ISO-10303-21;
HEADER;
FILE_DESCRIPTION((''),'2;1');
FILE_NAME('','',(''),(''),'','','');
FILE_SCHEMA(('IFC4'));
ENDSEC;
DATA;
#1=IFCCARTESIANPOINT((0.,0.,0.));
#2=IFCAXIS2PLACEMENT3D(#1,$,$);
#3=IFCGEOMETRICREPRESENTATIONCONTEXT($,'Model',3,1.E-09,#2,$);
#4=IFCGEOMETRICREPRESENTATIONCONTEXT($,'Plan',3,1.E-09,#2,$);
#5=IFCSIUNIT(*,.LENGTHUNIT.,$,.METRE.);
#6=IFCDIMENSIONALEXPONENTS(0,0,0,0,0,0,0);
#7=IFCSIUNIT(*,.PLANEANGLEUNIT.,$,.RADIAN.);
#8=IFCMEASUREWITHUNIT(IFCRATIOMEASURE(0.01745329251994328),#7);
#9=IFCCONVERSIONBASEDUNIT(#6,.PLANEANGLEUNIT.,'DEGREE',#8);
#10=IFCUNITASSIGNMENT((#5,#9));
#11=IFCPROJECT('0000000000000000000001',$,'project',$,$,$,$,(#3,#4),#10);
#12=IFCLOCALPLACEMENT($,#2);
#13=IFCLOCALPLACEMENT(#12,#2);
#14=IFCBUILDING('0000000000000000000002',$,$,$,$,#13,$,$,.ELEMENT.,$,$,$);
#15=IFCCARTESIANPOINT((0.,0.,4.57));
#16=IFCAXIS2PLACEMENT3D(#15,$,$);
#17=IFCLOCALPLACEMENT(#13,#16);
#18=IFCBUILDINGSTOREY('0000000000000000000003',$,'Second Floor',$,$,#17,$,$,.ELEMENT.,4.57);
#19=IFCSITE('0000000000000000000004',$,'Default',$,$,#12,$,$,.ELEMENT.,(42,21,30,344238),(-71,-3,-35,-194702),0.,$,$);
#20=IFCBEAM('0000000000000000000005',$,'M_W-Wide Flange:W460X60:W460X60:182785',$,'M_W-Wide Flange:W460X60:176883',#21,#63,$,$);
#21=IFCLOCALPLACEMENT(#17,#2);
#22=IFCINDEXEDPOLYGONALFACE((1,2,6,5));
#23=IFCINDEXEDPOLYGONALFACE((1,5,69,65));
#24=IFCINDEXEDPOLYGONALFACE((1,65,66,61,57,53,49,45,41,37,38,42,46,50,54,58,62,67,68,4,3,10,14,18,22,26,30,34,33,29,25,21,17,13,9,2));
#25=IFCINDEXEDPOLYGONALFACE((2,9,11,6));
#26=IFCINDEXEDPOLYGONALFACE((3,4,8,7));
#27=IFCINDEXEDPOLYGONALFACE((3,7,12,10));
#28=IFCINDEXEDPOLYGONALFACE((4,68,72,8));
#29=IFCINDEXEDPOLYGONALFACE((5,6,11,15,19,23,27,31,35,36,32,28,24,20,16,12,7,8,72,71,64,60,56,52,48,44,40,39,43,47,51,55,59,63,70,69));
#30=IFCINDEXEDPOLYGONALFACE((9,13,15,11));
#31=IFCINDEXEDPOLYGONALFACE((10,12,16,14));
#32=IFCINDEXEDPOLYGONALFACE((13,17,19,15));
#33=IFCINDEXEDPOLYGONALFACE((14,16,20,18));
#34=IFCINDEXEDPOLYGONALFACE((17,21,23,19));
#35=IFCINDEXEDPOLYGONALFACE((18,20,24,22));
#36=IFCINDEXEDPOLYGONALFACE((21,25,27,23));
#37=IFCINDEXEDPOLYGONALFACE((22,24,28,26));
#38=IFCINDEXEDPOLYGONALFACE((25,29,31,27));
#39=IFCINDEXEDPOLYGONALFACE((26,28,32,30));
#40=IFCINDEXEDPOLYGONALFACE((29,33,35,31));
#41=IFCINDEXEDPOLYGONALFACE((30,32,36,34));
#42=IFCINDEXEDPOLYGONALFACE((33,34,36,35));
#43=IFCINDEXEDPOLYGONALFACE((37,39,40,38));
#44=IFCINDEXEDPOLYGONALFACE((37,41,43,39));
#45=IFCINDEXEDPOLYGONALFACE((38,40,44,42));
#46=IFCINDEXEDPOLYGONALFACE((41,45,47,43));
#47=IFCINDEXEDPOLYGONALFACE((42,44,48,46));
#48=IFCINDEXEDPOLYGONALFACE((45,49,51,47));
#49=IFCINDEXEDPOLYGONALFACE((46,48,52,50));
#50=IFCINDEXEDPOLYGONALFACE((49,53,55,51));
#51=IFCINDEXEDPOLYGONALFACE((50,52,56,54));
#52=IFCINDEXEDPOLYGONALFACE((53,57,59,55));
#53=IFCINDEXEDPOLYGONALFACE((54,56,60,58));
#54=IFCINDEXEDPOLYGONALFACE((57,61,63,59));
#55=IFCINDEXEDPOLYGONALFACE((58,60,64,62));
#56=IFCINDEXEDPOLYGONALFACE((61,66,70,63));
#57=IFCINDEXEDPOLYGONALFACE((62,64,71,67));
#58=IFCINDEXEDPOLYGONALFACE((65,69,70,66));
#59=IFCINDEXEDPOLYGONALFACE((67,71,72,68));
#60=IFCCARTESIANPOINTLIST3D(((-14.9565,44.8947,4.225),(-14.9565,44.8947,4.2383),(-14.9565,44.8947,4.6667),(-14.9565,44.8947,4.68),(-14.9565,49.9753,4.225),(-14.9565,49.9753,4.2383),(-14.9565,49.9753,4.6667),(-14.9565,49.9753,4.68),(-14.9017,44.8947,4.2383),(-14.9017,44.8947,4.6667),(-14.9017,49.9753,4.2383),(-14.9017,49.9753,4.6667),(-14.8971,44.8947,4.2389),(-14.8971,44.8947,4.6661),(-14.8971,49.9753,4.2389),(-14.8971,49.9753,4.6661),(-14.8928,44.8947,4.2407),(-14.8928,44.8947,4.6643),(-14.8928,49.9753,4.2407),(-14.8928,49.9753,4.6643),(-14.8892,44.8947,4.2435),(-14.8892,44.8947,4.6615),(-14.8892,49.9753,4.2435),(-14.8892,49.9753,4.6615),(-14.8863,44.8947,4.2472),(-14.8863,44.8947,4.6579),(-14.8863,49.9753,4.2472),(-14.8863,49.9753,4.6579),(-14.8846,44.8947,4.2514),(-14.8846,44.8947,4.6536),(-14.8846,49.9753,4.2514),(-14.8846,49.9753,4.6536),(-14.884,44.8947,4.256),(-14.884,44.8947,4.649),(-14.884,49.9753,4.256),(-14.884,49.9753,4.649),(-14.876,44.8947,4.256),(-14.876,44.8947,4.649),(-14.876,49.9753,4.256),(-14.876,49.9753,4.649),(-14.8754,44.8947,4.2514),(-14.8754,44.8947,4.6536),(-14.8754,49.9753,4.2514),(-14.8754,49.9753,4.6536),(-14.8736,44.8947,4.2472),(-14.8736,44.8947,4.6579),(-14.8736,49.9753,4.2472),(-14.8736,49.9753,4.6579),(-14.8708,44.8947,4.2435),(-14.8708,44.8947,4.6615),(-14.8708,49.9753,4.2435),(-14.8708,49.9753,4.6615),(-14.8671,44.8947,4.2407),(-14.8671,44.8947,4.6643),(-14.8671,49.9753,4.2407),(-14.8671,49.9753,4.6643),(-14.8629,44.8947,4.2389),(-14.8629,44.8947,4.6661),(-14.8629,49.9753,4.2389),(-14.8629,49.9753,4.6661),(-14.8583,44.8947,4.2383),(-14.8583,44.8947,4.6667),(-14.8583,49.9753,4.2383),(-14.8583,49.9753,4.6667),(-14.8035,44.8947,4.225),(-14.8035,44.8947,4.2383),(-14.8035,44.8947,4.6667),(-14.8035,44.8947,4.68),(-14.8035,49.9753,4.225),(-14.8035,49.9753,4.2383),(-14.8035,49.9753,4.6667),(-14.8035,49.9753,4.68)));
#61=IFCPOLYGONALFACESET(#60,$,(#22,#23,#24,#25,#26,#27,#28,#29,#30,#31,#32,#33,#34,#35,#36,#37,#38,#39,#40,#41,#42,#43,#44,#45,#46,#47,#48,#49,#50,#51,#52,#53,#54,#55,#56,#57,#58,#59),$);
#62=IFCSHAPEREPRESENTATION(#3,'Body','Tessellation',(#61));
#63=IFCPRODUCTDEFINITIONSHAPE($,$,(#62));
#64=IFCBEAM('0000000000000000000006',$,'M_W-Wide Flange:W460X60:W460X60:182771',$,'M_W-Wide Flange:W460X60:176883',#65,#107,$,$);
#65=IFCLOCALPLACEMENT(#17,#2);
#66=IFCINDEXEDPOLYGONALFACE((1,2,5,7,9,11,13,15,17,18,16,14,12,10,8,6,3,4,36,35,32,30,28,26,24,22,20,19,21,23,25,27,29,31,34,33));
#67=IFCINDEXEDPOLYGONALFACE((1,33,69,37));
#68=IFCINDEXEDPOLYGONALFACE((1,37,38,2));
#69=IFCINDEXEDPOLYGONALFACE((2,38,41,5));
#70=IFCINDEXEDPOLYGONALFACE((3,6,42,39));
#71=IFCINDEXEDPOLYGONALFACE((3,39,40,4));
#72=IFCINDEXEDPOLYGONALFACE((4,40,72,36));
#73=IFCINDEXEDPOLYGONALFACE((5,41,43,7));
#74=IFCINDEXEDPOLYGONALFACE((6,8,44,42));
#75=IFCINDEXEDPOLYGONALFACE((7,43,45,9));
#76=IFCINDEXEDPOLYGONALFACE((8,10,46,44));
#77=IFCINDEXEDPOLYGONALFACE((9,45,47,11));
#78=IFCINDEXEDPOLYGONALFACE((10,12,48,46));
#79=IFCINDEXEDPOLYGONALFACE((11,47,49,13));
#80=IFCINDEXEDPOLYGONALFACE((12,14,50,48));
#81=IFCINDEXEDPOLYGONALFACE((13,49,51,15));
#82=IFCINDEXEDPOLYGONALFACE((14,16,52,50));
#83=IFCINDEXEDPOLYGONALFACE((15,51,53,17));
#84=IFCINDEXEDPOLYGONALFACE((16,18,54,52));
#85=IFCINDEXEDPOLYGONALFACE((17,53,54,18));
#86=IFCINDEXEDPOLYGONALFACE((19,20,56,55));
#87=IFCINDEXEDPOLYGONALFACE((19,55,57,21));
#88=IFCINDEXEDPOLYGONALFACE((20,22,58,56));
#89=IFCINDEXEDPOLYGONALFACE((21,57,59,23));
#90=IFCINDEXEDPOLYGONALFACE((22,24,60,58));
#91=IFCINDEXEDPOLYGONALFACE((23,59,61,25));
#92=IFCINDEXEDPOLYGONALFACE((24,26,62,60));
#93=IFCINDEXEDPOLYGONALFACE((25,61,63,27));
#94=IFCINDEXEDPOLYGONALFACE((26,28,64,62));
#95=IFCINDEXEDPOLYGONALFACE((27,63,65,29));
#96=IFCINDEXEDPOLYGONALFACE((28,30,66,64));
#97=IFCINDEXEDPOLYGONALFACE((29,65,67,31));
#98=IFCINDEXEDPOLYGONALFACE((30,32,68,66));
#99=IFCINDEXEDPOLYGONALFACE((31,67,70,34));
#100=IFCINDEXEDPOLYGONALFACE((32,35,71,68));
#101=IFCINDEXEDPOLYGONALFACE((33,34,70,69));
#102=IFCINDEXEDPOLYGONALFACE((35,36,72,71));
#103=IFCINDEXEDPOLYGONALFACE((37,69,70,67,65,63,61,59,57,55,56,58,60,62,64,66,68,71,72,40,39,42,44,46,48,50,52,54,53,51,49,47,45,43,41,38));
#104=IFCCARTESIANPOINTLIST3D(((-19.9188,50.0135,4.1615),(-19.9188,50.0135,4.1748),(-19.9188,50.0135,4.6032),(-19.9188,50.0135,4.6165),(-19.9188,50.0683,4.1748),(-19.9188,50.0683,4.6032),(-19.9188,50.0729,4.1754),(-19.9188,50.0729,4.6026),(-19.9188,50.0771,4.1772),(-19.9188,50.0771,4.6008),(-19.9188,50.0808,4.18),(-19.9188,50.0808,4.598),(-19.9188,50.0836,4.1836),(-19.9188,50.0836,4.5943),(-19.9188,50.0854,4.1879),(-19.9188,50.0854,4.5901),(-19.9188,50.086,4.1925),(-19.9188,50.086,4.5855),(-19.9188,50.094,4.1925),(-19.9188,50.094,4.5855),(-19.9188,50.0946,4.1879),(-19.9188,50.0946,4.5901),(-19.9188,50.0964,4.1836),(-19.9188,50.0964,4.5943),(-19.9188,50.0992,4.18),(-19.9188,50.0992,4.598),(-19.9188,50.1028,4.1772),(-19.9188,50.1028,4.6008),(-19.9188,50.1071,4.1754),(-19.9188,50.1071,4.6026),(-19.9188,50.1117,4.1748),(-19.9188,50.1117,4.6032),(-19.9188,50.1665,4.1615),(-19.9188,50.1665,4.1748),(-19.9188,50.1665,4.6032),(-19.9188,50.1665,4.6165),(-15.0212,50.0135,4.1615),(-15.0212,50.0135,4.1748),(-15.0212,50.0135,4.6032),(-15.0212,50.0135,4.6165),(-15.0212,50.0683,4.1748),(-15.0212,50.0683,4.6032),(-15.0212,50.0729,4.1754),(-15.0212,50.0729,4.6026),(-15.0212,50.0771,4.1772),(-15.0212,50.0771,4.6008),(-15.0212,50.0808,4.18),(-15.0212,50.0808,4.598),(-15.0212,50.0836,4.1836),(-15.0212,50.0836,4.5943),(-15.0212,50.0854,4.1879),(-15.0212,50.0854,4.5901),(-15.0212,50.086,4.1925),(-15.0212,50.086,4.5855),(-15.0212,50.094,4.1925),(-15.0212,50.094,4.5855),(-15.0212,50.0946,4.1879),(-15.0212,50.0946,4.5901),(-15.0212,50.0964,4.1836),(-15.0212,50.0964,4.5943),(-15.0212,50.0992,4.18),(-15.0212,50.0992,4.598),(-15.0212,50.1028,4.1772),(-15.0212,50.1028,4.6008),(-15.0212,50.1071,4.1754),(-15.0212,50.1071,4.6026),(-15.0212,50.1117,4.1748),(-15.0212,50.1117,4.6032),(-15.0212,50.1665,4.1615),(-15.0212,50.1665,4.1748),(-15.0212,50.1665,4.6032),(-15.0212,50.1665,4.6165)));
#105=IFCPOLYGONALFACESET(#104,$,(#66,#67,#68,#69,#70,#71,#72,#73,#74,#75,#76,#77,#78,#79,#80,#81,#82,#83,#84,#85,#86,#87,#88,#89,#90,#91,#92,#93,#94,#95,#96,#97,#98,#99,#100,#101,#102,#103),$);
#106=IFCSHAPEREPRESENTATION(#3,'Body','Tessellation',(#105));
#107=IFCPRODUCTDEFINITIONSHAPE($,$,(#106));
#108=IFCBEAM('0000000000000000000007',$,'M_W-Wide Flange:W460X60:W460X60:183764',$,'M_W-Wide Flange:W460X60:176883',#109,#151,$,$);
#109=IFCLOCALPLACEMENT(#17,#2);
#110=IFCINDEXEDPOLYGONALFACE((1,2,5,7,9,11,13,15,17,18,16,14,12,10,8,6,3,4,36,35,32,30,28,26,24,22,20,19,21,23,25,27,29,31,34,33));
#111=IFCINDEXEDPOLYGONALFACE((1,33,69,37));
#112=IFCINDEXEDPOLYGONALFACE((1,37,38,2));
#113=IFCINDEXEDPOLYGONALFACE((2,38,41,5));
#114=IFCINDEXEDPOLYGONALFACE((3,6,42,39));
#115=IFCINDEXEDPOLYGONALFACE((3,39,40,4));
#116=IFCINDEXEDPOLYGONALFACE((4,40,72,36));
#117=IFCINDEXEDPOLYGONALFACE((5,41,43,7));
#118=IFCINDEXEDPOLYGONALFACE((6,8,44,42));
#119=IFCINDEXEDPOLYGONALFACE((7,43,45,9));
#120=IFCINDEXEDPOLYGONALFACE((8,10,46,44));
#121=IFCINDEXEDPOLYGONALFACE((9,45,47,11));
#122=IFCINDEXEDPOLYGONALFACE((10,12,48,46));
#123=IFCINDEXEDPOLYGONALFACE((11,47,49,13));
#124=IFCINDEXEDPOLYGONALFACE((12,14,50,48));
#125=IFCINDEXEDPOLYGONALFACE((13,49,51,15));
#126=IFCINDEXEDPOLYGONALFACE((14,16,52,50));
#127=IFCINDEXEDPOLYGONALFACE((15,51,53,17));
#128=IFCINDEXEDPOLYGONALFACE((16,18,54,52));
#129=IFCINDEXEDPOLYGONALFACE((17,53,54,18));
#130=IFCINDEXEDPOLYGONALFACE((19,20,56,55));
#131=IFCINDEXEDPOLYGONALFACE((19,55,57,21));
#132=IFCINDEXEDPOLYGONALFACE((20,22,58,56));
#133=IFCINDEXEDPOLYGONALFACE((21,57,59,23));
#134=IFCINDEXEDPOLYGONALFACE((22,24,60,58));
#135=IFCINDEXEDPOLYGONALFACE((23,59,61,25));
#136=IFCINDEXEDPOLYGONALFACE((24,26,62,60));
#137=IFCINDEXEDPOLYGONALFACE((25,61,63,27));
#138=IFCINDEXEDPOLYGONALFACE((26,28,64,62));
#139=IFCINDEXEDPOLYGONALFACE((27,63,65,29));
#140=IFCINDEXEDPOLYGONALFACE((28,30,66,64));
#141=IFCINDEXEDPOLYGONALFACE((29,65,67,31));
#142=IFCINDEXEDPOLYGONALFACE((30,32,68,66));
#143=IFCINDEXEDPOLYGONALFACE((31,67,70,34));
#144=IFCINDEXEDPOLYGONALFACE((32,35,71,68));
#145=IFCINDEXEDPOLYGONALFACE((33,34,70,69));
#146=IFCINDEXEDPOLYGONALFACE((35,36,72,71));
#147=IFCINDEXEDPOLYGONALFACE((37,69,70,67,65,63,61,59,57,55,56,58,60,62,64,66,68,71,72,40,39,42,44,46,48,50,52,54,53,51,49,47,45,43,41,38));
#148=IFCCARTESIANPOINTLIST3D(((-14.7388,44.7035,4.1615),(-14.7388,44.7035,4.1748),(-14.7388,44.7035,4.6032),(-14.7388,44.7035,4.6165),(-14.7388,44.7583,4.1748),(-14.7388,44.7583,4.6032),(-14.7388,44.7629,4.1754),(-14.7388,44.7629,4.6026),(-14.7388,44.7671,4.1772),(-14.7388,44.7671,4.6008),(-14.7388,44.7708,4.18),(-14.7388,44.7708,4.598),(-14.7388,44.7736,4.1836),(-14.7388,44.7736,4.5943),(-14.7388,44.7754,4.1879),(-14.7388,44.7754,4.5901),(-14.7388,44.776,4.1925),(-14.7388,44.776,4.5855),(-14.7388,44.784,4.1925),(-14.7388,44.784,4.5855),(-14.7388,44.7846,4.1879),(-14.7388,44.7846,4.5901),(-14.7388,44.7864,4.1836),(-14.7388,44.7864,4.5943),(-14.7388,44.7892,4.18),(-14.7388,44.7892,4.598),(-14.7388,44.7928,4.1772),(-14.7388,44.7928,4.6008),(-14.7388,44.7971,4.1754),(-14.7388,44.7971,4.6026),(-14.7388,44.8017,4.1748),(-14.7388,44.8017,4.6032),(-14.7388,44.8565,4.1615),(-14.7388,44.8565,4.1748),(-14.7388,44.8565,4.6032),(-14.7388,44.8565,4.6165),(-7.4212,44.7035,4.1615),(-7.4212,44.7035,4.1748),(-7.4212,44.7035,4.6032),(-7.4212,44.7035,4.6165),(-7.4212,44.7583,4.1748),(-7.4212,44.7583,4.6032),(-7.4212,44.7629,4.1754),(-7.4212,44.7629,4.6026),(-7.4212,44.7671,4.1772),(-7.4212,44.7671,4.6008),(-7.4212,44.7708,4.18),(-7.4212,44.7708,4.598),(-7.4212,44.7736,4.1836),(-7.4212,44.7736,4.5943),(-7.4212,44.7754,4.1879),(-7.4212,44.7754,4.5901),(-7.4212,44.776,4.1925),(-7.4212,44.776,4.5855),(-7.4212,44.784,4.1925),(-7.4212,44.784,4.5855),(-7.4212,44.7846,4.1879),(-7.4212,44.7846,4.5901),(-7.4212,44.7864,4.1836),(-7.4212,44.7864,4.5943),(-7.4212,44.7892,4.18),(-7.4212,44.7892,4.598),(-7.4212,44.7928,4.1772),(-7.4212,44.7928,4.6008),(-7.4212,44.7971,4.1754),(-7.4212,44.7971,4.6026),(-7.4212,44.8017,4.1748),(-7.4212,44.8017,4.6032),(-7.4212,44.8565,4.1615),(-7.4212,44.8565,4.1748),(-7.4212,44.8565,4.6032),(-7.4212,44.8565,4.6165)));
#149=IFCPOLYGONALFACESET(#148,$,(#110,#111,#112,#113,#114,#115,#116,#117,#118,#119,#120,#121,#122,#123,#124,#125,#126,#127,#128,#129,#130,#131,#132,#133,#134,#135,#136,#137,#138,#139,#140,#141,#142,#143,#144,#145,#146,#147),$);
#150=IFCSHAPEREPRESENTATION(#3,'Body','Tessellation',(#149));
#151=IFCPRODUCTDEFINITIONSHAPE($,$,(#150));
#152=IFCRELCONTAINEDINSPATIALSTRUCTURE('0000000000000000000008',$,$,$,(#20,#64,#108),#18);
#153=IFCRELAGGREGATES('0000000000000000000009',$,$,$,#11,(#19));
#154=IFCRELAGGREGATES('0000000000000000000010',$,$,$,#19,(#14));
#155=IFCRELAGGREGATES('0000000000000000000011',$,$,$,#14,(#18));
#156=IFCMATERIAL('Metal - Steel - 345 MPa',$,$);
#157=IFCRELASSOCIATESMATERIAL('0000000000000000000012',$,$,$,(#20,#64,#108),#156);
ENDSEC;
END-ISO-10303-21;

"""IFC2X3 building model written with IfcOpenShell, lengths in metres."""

from ifc_helpers import new_model, entity, si_unit, converted_unit, frame, frame_2d, origin, place, context, project, spatial, polyline, circle_curve, parameter, trimmed, segment, composite_curve, outline, extrude, material, element, save


model = new_model("IFC2X3")

# Units and contexts
model_context = context("Model", 3, precision=1e-09, world=origin())
plan_context = context("Plan", 3, precision=1e-09, world=origin())
ifc_project = project(units=[si_unit("LENGTHUNIT", "METRE"), converted_unit("PLANEANGLEUNIT", "DEGREE", entity("IfcRatioMeasure", 0.01745329251994328), si_unit("PLANEANGLEUNIT", "RADIAN"), dimensions=[0, 0, 0, 0, 0, 0, 0])], contexts=[model_context, plan_context])

# Site, building, storey
site_placement = place(None, origin())
site = spatial("IfcSite", under=ifc_project, at=site_placement, Name="Default", CompositionType="ELEMENT", RefLatitude=(42, 21, 30, 344238), RefLongitude=(-71, -3, -35, -194702), RefElevation=0.0)
building_placement = place(site_placement, origin())
building = spatial("IfcBuilding", under=site, at=building_placement, CompositionType="ELEMENT")
storey_placement = place(building_placement, frame((0.0, 0.0, 4.57)))
storey = spatial("IfcBuildingStorey", under=building, at=storey_placement, Name="Second Floor", CompositionType="ELEMENT", Elevation=4.57)

# Shared definitions
ifc_material = material(Name="Metal - Steel - 345 MPa")

# Beams
beam_1_placement = place(storey_placement, frame((-14.88, 50.0864, 4.68), z_axis=(0.0, 0.0, 1.0), x_axis=(-1.0, 0.0, 0.0)))
element("IfcBeam", 1, at=beam_1_placement, inside=storey, material=ifc_material, Name="M_W-Wide Flange:W460X60:W460X60:182785", ObjectType="M_W-Wide Flange:W460X60:176883", context=model_context, shape_type="SweptSolid", body=[
    extrude(outline(composite_curve([segment(polyline([(0.2142, -0.0765), (0.2275, -0.0765)]), True, "CONTINUOUS"), segment(polyline([(0.2275, -0.0765), (0.2275, 0.0765)]), True, "CONTINUOUS"), segment(polyline([(0.2275, 0.0765), (0.2142, 0.0765)]), True, "CONTINUOUS"), segment(polyline([(0.2142, 0.0765), (0.2142, 0.0217)]), True, "CONTINUOUS"), segment(trimmed(circle_curve(frame_2d((0.1965, 0.0217), x_axis=(1.0, 0.0)), 0.0177), [parameter(270.0)], [parameter(360.0)], True, "PARAMETER"), False, "CONTINUOUS"), segment(polyline([(0.1965, 0.004), (-0.1965, 0.004)]), True, "CONTINUOUS"), segment(trimmed(circle_curve(frame_2d((-0.1965, 0.0217), x_axis=(0.0, -1.0)), 0.0177), [parameter(270.0)], [parameter(360.0)], True, "PARAMETER"), False, "CONTINUOUS"), segment(polyline([(-0.2142, 0.0217), (-0.2142, 0.0765)]), True, "CONTINUOUS"), segment(polyline([(-0.2142, 0.0765), (-0.2275, 0.0765)]), True, "CONTINUOUS"), segment(polyline([(-0.2275, 0.0765), (-0.2275, -0.0765)]), True, "CONTINUOUS"), segment(polyline([(-0.2275, -0.0765), (-0.2142, -0.0765)]), True, "CONTINUOUS"), segment(polyline([(-0.2142, -0.0765), (-0.2142, -0.0217)]), True, "CONTINUOUS"), segment(trimmed(circle_curve(frame_2d((-0.1965, -0.0217), x_axis=(-1.0, 0.0)), 0.0177), [parameter(270.0)], [parameter(360.0)], True, "PARAMETER"), False, "CONTINUOUS"), segment(polyline([(-0.1965, -0.004), (0.1965, -0.004)]), True, "CONTINUOUS"), segment(trimmed(circle_curve(frame_2d((0.1965, -0.0217), x_axis=(0.0, 1.0)), 0.0177), [parameter(270.0)], [parameter(0.0)], True, "PARAMETER"), False, "CONTINUOUS"), segment(polyline([(0.2142, -0.0217), (0.2142, -0.0765)]), True, "CONTINUOUS")], self_intersect=False)), frame((0.0, 5.1917, -0.2275), z_axis=(0.0, -1.0, 0.0), x_axis=(0.0, 0.0, -1.0)), (0.0, 0.0, 1.0), 5.0806),
])
beam_2_placement = place(storey_placement, frame((-20.0564, 50.09, 4.6165), z_axis=(0.0, 0.0, 1.0), x_axis=(0.0, -1.0, 0.0)))
element("IfcBeam", 2, at=beam_2_placement, inside=storey, material=ifc_material, Name="M_W-Wide Flange:W460X60:W460X60:182771", ObjectType="M_W-Wide Flange:W460X60:176883", context=model_context, shape_type="SweptSolid", body=[
    extrude(outline(composite_curve([segment(polyline([(-0.0765, -0.2142), (-0.0765, -0.2275)]), True, "CONTINUOUS"), segment(polyline([(-0.0765, -0.2275), (0.0765, -0.2275)]), True, "CONTINUOUS"), segment(polyline([(0.0765, -0.2275), (0.0765, -0.2142)]), True, "CONTINUOUS"), segment(polyline([(0.0765, -0.2142), (0.0217, -0.2142)]), True, "CONTINUOUS"), segment(trimmed(circle_curve(frame_2d((0.0217, -0.1965), x_axis=(0.0, -1.0)), 0.0177), [parameter(270.0)], [parameter(360.0)], True, "PARAMETER"), False, "CONTINUOUS"), segment(polyline([(0.004, -0.1965), (0.004, 0.1965)]), True, "CONTINUOUS"), segment(trimmed(circle_curve(frame_2d((0.0217, 0.1965), x_axis=(-1.0, 0.0)), 0.0177), [parameter(270.0)], [parameter(360.0)], True, "PARAMETER"), False, "CONTINUOUS"), segment(polyline([(0.0217, 0.2142), (0.0765, 0.2142)]), True, "CONTINUOUS"), segment(polyline([(0.0765, 0.2142), (0.0765, 0.2275)]), True, "CONTINUOUS"), segment(polyline([(0.0765, 0.2275), (-0.0765, 0.2275)]), True, "CONTINUOUS"), segment(polyline([(-0.0765, 0.2275), (-0.0765, 0.2142)]), True, "CONTINUOUS"), segment(polyline([(-0.0765, 0.2142), (-0.0217, 0.2142)]), True, "CONTINUOUS"), segment(trimmed(circle_curve(frame_2d((-0.0217, 0.1965), x_axis=(0.0, 1.0)), 0.0177), [parameter(270.0)], [parameter(360.0)], True, "PARAMETER"), False, "CONTINUOUS"), segment(polyline([(-0.004, 0.1965), (-0.004, -0.1965)]), True, "CONTINUOUS"), segment(trimmed(circle_curve(frame_2d((-0.0217, -0.1965), x_axis=(1.0, 0.0)), 0.0177), [parameter(270.0)], [parameter(0.0)], True, "PARAMETER"), False, "CONTINUOUS"), segment(polyline([(-0.0217, -0.2142), (-0.0765, -0.2142)]), True, "CONTINUOUS")], self_intersect=False)), frame((0.0, 0.1376, -0.2275), z_axis=(0.0, -1.0, 0.0), x_axis=(1.0, 0.0, 0.0)), (0.0, 0.0, -1.0), 4.8976),
])
beam_3_placement = place(storey_placement, frame((-14.8775, 44.78, 4.6165), z_axis=(0.0, 0.0, 1.0), x_axis=(0.0, -1.0, 0.0)))
element("IfcBeam", 3, at=beam_3_placement, inside=storey, material=ifc_material, Name="M_W-Wide Flange:W460X60:W460X60:183764", ObjectType="M_W-Wide Flange:W460X60:176883", context=model_context, shape_type="SweptSolid", body=[
    extrude(outline(composite_curve([segment(polyline([(-0.0765, -0.2142), (-0.0765, -0.2275)]), True, "CONTINUOUS"), segment(polyline([(-0.0765, -0.2275), (0.0765, -0.2275)]), True, "CONTINUOUS"), segment(polyline([(0.0765, -0.2275), (0.0765, -0.2142)]), True, "CONTINUOUS"), segment(polyline([(0.0765, -0.2142), (0.0217, -0.2142)]), True, "CONTINUOUS"), segment(trimmed(circle_curve(frame_2d((0.0217, -0.1965), x_axis=(0.0, -1.0)), 0.0177), [parameter(270.0)], [parameter(360.0)], True, "PARAMETER"), False, "CONTINUOUS"), segment(polyline([(0.004, -0.1965), (0.004, 0.1965)]), True, "CONTINUOUS"), segment(trimmed(circle_curve(frame_2d((0.0217, 0.1965), x_axis=(-1.0, 0.0)), 0.0177), [parameter(270.0)], [parameter(360.0)], True, "PARAMETER"), False, "CONTINUOUS"), segment(polyline([(0.0217, 0.2142), (0.0765, 0.2142)]), True, "CONTINUOUS"), segment(polyline([(0.0765, 0.2142), (0.0765, 0.2275)]), True, "CONTINUOUS"), segment(polyline([(0.0765, 0.2275), (-0.0765, 0.2275)]), True, "CONTINUOUS"), segment(polyline([(-0.0765, 0.2275), (-0.0765, 0.2142)]), True, "CONTINUOUS"), segment(polyline([(-0.0765, 0.2142), (-0.0217, 0.2142)]), True, "CONTINUOUS"), segment(trimmed(circle_curve(frame_2d((-0.0217, 0.1965), x_axis=(0.0, 1.0)), 0.0177), [parameter(270.0)], [parameter(360.0)], True, "PARAMETER"), False, "CONTINUOUS"), segment(polyline([(-0.004, 0.1965), (-0.004, -0.1965)]), True, "CONTINUOUS"), segment(trimmed(circle_curve(frame_2d((-0.0217, -0.1965), x_axis=(1.0, 0.0)), 0.0177), [parameter(270.0)], [parameter(0.0)], True, "PARAMETER"), False, "CONTINUOUS"), segment(polyline([(-0.0217, -0.2142), (-0.0765, -0.2142)]), True, "CONTINUOUS")], self_intersect=False)), frame((0.0, 0.1387, -0.2275), z_axis=(0.0, -1.0, 0.0), x_axis=(1.0, 0.0, 0.0)), (0.0, 0.0, -1.0), 7.3176),
])

save(model, "model.ifc")
